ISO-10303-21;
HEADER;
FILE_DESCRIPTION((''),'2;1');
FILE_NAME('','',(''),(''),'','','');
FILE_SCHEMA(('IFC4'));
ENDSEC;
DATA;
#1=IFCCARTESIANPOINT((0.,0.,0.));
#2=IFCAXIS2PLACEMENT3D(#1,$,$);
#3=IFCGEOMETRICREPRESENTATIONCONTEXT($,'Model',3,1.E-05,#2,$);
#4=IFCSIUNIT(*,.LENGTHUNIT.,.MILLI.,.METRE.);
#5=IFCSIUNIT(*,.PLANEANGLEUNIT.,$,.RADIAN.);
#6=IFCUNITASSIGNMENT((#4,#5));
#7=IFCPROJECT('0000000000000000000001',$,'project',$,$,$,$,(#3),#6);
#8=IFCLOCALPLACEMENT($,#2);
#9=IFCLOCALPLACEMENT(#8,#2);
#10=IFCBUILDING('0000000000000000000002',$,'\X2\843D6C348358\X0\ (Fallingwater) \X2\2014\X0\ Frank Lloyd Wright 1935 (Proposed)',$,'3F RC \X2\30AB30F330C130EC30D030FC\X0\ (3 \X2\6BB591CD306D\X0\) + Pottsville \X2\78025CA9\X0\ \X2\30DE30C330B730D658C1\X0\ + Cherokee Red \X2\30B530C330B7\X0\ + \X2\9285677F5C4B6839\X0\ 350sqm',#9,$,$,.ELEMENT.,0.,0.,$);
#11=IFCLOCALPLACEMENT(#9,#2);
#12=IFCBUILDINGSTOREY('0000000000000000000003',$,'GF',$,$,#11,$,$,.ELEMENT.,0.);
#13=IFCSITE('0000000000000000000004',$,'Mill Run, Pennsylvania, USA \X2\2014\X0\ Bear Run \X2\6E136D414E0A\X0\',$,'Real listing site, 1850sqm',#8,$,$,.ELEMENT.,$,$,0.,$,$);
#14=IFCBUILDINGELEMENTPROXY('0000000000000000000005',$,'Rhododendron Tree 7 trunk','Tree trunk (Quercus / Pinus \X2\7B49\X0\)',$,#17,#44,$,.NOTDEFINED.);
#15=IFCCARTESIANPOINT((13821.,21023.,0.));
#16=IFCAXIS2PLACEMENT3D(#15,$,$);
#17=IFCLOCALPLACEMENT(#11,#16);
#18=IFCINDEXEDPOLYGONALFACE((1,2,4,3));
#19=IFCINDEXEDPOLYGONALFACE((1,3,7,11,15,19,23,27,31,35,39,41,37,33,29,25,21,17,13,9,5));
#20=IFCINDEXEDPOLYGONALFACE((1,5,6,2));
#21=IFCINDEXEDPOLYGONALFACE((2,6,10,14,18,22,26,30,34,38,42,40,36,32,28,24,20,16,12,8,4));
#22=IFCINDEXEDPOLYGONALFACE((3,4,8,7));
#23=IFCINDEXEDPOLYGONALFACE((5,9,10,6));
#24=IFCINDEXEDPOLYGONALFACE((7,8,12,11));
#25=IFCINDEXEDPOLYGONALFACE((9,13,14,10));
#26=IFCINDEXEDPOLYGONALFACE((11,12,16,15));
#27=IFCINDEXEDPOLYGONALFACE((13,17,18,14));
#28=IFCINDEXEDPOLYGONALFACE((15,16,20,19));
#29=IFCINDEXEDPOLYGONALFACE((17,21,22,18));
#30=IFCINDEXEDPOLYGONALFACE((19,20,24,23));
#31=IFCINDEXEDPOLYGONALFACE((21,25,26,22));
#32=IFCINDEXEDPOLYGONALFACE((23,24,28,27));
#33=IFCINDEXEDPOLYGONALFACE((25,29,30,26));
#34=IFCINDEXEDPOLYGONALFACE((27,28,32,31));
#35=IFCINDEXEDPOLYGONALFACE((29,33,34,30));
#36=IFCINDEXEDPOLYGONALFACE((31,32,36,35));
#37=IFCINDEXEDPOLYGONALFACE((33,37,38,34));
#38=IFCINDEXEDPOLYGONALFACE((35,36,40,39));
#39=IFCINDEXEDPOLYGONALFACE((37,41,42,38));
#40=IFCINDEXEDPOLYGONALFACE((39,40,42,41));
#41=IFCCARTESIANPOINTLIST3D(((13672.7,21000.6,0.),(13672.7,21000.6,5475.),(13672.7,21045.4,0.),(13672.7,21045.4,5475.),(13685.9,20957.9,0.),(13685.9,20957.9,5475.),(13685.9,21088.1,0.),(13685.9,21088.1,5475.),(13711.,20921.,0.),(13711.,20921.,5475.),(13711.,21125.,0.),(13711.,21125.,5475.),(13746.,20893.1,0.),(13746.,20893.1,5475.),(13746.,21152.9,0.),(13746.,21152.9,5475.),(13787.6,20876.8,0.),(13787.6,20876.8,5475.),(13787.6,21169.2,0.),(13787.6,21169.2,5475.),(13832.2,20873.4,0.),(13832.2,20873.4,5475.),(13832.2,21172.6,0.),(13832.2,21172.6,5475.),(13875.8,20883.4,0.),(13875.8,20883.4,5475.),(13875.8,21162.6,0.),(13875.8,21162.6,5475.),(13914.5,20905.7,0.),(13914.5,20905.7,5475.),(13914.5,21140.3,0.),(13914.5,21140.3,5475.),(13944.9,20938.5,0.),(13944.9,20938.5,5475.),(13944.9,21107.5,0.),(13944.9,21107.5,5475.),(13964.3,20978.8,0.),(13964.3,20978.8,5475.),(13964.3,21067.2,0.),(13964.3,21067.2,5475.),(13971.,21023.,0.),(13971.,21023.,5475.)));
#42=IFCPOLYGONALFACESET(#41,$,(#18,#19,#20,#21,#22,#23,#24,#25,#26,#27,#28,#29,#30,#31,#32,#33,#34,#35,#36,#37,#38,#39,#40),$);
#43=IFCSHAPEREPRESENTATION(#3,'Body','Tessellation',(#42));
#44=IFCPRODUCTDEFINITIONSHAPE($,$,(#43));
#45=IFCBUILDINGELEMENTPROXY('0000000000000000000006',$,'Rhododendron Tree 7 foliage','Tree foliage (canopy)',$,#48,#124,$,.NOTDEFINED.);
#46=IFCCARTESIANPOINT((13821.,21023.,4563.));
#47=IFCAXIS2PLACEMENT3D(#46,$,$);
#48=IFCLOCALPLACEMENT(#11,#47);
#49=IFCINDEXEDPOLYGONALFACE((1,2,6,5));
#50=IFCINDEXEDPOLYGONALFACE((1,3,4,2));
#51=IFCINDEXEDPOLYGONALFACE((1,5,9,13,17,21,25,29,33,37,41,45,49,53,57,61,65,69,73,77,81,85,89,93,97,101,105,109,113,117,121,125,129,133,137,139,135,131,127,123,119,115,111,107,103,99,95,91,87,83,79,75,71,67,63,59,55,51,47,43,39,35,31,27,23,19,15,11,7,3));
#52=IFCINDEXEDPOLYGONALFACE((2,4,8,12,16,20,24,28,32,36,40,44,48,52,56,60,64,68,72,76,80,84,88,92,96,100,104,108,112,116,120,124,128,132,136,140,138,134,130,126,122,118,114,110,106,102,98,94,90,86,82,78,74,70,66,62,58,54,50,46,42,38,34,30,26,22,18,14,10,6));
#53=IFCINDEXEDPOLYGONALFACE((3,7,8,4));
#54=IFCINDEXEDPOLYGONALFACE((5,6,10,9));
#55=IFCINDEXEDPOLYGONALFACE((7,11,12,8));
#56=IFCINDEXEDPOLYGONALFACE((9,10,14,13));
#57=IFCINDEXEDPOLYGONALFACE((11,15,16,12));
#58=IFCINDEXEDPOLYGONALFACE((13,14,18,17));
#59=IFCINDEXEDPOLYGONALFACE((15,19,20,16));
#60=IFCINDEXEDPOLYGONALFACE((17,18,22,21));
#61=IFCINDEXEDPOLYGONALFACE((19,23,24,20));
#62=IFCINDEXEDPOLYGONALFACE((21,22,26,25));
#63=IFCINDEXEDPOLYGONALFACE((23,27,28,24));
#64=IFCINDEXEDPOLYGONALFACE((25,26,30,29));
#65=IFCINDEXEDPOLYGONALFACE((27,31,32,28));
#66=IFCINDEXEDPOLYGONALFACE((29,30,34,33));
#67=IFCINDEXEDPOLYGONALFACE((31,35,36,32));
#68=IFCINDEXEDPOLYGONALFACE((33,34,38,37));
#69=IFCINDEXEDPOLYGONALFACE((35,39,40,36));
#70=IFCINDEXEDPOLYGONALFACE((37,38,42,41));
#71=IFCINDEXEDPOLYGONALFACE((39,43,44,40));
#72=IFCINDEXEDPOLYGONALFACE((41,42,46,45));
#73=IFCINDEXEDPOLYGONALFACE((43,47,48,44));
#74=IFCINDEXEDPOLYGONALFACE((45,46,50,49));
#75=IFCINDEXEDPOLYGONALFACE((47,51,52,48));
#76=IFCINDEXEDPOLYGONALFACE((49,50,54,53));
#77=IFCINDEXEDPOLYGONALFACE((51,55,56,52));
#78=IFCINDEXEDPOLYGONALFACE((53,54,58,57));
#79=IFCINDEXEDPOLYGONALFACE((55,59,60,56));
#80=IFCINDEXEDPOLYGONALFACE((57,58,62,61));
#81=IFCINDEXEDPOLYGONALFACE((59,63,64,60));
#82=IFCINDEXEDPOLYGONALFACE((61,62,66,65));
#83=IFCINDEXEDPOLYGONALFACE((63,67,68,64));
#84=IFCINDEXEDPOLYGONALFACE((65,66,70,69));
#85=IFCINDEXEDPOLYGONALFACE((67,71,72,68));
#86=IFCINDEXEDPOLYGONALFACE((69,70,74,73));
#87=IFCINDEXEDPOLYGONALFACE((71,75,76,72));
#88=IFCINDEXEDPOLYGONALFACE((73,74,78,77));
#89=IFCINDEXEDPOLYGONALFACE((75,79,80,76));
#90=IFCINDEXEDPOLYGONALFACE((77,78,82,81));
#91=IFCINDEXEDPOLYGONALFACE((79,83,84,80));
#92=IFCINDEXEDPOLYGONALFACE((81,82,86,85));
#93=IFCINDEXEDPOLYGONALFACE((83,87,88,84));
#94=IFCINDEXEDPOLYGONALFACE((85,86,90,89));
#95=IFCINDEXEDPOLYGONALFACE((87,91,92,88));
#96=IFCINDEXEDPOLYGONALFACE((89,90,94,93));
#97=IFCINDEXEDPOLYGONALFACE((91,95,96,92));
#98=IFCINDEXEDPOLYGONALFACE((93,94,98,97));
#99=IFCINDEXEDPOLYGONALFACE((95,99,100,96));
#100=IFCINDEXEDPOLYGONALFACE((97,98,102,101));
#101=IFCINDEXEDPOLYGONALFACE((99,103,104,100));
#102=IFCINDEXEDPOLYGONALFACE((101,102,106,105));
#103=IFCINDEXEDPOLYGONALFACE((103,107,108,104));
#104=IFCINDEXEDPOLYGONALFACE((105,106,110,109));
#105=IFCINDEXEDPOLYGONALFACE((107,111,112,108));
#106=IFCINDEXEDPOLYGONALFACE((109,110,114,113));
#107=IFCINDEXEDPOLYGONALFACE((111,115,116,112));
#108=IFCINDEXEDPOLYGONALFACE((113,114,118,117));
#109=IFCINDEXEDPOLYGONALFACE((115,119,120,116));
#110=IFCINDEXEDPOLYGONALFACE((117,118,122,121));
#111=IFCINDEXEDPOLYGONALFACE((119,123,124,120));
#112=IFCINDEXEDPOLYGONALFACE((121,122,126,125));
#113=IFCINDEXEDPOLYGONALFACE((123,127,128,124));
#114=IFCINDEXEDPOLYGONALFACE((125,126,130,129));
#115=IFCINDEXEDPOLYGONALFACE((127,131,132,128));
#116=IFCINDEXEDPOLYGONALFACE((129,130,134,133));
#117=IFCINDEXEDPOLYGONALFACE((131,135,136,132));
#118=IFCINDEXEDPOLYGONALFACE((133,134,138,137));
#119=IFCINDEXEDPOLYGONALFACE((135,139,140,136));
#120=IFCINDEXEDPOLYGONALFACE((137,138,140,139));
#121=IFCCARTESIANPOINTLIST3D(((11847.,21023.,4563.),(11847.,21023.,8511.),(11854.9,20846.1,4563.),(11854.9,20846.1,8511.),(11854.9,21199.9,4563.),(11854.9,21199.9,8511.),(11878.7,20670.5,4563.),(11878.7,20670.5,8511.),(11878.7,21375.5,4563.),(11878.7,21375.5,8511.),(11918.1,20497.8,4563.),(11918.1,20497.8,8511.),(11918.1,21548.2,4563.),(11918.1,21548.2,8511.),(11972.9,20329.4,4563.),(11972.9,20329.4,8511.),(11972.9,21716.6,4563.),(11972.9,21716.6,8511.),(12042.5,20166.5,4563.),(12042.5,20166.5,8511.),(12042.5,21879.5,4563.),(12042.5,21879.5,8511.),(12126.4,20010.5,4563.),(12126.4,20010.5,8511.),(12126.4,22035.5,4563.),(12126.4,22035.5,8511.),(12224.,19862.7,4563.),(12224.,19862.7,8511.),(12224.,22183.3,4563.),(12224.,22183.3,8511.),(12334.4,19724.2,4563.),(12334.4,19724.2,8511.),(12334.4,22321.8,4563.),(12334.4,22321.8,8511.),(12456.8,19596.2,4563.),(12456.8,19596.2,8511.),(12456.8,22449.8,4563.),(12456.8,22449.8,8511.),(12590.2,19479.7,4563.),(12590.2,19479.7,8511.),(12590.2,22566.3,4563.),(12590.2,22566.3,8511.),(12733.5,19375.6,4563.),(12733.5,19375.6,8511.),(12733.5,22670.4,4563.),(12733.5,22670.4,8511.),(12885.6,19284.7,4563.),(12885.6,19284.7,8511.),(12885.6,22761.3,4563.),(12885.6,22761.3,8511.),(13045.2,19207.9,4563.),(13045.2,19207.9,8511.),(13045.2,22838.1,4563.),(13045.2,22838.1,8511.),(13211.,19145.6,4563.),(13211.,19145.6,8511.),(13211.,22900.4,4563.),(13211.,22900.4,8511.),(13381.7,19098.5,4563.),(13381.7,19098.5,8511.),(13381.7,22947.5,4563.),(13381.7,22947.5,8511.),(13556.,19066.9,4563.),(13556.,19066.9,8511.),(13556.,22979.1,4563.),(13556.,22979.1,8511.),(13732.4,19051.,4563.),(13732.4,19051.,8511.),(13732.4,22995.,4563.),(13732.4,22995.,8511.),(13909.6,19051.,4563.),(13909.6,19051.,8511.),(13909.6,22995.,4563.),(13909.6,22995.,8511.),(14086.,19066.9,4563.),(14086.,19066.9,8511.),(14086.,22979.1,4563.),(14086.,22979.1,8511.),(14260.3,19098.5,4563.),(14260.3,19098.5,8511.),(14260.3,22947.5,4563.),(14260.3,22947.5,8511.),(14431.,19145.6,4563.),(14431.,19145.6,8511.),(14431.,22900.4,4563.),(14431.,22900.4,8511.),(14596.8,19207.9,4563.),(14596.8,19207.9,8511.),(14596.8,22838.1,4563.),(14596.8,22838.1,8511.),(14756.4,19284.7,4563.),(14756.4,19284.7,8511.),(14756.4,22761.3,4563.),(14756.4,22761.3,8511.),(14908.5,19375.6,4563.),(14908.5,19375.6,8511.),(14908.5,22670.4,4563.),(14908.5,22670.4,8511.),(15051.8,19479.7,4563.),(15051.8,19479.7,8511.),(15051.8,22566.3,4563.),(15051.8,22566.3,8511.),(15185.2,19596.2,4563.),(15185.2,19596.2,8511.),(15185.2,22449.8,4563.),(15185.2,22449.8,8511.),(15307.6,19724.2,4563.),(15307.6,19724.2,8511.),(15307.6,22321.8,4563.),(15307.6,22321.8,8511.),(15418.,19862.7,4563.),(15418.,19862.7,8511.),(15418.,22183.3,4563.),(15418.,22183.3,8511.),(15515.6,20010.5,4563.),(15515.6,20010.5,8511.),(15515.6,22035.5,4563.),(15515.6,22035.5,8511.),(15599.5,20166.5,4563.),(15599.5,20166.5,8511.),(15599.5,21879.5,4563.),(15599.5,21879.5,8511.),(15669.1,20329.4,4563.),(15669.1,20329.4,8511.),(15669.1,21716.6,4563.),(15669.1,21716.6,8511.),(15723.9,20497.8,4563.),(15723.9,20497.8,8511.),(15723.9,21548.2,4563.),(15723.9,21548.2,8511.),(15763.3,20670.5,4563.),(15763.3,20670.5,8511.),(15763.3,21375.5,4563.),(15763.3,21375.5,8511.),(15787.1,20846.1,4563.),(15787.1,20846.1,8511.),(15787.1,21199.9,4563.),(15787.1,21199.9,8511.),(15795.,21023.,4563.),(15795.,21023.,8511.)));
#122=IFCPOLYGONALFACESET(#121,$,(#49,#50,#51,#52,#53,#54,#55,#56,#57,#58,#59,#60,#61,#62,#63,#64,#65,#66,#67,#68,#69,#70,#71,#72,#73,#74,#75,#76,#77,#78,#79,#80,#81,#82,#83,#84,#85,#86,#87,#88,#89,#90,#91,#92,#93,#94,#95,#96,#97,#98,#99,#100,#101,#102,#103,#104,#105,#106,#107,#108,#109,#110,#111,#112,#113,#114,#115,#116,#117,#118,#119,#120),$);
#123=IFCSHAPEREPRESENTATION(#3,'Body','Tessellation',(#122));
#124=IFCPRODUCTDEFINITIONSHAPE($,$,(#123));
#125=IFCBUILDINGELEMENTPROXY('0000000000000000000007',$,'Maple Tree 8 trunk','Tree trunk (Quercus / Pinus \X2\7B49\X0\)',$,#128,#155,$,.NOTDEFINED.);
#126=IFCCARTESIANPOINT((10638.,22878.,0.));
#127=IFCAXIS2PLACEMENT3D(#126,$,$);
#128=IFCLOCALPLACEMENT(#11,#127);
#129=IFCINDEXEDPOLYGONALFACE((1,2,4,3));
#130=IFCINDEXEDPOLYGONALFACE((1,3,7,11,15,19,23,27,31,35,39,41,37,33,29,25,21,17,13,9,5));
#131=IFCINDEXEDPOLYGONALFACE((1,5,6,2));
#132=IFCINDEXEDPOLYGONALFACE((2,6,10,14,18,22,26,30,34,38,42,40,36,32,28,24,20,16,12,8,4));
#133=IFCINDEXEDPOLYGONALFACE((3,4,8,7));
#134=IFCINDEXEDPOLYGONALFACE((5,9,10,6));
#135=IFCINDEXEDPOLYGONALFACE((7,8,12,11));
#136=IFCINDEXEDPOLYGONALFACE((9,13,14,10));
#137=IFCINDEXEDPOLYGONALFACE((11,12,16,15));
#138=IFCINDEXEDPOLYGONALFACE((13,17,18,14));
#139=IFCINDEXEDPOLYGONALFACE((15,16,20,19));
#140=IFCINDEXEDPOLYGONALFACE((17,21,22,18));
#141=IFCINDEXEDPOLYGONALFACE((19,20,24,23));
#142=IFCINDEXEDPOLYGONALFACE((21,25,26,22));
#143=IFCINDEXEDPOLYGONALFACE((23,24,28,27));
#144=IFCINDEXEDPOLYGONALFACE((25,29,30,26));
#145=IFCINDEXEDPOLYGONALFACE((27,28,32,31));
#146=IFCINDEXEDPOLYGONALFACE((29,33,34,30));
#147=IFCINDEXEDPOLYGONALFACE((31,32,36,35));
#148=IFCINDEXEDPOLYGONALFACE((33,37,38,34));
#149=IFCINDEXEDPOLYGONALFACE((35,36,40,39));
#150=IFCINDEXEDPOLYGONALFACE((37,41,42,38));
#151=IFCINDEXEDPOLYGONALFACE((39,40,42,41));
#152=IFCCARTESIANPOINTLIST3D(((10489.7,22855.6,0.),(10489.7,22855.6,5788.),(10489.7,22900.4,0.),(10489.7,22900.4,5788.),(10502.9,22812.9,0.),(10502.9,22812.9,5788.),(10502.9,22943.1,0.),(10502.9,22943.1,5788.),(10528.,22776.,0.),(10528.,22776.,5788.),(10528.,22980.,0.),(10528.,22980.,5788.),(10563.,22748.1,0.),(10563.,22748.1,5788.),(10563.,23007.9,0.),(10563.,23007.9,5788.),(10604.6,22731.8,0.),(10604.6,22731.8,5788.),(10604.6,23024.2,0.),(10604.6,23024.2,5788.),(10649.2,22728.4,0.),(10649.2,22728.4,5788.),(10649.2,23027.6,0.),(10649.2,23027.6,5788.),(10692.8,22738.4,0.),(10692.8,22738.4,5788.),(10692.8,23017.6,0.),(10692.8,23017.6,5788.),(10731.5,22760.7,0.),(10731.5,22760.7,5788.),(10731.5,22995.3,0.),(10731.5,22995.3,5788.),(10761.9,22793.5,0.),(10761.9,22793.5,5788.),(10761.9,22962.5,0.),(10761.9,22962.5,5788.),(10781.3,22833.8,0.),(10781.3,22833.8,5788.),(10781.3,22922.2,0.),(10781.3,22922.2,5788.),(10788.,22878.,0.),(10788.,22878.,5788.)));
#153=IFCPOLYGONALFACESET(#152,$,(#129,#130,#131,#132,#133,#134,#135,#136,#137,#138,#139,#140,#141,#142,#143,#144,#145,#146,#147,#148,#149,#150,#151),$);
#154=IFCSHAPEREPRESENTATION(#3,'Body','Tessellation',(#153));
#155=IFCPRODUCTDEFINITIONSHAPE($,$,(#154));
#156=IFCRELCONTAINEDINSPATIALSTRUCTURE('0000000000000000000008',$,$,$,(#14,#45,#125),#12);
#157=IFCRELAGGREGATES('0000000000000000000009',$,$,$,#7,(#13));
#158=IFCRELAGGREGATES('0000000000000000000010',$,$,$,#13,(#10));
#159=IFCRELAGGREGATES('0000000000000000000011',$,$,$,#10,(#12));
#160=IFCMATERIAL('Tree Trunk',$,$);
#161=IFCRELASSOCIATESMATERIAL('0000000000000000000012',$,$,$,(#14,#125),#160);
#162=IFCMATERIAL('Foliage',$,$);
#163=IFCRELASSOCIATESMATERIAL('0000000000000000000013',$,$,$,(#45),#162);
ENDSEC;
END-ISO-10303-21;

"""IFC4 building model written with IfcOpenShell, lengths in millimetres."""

from ifc_helpers import new_model, si_unit, frame, origin, origin_2d, place, context, project, spatial, circle, extrude, material, element, save


model = new_model("IFC4")

# Units and contexts
model_context = context("Model", 3, precision=1e-05, world=origin())
ifc_project = project(units=[si_unit("LENGTHUNIT", "METRE", prefix="MILLI"), si_unit("PLANEANGLEUNIT", "RADIAN")], contexts=[model_context])

# Site, building, storey
site_placement = place(None, origin())
site = spatial("IfcSite", under=ifc_project, at=site_placement, Name="Mill Run, Pennsylvania, USA — Bear Run 渓流上", ObjectType="Real listing site, 1850sqm", CompositionType="ELEMENT", RefElevation=0.0)
building_placement = place(site_placement, origin())
building = spatial("IfcBuilding", under=site, at=building_placement, Name="落水荘 (Fallingwater) — Frank Lloyd Wright 1935 (Proposed)", ObjectType="3F RC カンチレバー (3 段重ね) + Pottsville 砂岩 マッシブ壁 + Cherokee Red サッシ + 銅板屋根 350sqm", CompositionType="ELEMENT", ElevationOfRefHeight=0.0, ElevationOfTerrain=0.0)
storey_placement = place(building_placement, origin())
storey = spatial("IfcBuildingStorey", under=building, at=storey_placement, Name="GF", CompositionType="ELEMENT", Elevation=0.0)

# Building element proxies
ifc_material_1 = material(Name="Tree Trunk")
ifc_material_2 = material(Name="Foliage")
proxy_1_placement = place(storey_placement, frame((13821.0, 21023.0, 0.0)))
element("IfcBuildingElementProxy", 1, at=proxy_1_placement, inside=storey, material=ifc_material_1, Name="Rhododendron Tree 7 trunk", Description="Tree trunk (Quercus / Pinus 等)", PredefinedType="NOTDEFINED", context=model_context, shape_type="SweptSolid", body=[
    extrude(circle(Radius=150.0, at=origin_2d()), frame((13821.0, 21023.0, 0.0)), (0.0, 0.0, 1.0), 5475.0),
])
proxy_2_placement = place(storey_placement, frame((13821.0, 21023.0, 4563.0)))
element("IfcBuildingElementProxy", 2, at=proxy_2_placement, inside=storey, material=ifc_material_2, Name="Rhododendron Tree 7 foliage", Description="Tree foliage (canopy)", PredefinedType="NOTDEFINED", context=model_context, shape_type="SweptSolid", body=[
    extrude(circle(Radius=1974.0, at=origin_2d()), frame((13821.0, 21023.0, 4563.0)), (0.0, 0.0, 1.0), 3948.0),
])
proxy_3_placement = place(storey_placement, frame((10638.0, 22878.0, 0.0)))
element("IfcBuildingElementProxy", 3, at=proxy_3_placement, inside=storey, material=ifc_material_1, Name="Maple Tree 8 trunk", Description="Tree trunk (Quercus / Pinus 等)", PredefinedType="NOTDEFINED", context=model_context, shape_type="SweptSolid", body=[
    extrude(circle(Radius=150.0, at=origin_2d()), frame((10638.0, 22878.0, 0.0)), (0.0, 0.0, 1.0), 5788.0),
])

save(model, "model.ifc")
